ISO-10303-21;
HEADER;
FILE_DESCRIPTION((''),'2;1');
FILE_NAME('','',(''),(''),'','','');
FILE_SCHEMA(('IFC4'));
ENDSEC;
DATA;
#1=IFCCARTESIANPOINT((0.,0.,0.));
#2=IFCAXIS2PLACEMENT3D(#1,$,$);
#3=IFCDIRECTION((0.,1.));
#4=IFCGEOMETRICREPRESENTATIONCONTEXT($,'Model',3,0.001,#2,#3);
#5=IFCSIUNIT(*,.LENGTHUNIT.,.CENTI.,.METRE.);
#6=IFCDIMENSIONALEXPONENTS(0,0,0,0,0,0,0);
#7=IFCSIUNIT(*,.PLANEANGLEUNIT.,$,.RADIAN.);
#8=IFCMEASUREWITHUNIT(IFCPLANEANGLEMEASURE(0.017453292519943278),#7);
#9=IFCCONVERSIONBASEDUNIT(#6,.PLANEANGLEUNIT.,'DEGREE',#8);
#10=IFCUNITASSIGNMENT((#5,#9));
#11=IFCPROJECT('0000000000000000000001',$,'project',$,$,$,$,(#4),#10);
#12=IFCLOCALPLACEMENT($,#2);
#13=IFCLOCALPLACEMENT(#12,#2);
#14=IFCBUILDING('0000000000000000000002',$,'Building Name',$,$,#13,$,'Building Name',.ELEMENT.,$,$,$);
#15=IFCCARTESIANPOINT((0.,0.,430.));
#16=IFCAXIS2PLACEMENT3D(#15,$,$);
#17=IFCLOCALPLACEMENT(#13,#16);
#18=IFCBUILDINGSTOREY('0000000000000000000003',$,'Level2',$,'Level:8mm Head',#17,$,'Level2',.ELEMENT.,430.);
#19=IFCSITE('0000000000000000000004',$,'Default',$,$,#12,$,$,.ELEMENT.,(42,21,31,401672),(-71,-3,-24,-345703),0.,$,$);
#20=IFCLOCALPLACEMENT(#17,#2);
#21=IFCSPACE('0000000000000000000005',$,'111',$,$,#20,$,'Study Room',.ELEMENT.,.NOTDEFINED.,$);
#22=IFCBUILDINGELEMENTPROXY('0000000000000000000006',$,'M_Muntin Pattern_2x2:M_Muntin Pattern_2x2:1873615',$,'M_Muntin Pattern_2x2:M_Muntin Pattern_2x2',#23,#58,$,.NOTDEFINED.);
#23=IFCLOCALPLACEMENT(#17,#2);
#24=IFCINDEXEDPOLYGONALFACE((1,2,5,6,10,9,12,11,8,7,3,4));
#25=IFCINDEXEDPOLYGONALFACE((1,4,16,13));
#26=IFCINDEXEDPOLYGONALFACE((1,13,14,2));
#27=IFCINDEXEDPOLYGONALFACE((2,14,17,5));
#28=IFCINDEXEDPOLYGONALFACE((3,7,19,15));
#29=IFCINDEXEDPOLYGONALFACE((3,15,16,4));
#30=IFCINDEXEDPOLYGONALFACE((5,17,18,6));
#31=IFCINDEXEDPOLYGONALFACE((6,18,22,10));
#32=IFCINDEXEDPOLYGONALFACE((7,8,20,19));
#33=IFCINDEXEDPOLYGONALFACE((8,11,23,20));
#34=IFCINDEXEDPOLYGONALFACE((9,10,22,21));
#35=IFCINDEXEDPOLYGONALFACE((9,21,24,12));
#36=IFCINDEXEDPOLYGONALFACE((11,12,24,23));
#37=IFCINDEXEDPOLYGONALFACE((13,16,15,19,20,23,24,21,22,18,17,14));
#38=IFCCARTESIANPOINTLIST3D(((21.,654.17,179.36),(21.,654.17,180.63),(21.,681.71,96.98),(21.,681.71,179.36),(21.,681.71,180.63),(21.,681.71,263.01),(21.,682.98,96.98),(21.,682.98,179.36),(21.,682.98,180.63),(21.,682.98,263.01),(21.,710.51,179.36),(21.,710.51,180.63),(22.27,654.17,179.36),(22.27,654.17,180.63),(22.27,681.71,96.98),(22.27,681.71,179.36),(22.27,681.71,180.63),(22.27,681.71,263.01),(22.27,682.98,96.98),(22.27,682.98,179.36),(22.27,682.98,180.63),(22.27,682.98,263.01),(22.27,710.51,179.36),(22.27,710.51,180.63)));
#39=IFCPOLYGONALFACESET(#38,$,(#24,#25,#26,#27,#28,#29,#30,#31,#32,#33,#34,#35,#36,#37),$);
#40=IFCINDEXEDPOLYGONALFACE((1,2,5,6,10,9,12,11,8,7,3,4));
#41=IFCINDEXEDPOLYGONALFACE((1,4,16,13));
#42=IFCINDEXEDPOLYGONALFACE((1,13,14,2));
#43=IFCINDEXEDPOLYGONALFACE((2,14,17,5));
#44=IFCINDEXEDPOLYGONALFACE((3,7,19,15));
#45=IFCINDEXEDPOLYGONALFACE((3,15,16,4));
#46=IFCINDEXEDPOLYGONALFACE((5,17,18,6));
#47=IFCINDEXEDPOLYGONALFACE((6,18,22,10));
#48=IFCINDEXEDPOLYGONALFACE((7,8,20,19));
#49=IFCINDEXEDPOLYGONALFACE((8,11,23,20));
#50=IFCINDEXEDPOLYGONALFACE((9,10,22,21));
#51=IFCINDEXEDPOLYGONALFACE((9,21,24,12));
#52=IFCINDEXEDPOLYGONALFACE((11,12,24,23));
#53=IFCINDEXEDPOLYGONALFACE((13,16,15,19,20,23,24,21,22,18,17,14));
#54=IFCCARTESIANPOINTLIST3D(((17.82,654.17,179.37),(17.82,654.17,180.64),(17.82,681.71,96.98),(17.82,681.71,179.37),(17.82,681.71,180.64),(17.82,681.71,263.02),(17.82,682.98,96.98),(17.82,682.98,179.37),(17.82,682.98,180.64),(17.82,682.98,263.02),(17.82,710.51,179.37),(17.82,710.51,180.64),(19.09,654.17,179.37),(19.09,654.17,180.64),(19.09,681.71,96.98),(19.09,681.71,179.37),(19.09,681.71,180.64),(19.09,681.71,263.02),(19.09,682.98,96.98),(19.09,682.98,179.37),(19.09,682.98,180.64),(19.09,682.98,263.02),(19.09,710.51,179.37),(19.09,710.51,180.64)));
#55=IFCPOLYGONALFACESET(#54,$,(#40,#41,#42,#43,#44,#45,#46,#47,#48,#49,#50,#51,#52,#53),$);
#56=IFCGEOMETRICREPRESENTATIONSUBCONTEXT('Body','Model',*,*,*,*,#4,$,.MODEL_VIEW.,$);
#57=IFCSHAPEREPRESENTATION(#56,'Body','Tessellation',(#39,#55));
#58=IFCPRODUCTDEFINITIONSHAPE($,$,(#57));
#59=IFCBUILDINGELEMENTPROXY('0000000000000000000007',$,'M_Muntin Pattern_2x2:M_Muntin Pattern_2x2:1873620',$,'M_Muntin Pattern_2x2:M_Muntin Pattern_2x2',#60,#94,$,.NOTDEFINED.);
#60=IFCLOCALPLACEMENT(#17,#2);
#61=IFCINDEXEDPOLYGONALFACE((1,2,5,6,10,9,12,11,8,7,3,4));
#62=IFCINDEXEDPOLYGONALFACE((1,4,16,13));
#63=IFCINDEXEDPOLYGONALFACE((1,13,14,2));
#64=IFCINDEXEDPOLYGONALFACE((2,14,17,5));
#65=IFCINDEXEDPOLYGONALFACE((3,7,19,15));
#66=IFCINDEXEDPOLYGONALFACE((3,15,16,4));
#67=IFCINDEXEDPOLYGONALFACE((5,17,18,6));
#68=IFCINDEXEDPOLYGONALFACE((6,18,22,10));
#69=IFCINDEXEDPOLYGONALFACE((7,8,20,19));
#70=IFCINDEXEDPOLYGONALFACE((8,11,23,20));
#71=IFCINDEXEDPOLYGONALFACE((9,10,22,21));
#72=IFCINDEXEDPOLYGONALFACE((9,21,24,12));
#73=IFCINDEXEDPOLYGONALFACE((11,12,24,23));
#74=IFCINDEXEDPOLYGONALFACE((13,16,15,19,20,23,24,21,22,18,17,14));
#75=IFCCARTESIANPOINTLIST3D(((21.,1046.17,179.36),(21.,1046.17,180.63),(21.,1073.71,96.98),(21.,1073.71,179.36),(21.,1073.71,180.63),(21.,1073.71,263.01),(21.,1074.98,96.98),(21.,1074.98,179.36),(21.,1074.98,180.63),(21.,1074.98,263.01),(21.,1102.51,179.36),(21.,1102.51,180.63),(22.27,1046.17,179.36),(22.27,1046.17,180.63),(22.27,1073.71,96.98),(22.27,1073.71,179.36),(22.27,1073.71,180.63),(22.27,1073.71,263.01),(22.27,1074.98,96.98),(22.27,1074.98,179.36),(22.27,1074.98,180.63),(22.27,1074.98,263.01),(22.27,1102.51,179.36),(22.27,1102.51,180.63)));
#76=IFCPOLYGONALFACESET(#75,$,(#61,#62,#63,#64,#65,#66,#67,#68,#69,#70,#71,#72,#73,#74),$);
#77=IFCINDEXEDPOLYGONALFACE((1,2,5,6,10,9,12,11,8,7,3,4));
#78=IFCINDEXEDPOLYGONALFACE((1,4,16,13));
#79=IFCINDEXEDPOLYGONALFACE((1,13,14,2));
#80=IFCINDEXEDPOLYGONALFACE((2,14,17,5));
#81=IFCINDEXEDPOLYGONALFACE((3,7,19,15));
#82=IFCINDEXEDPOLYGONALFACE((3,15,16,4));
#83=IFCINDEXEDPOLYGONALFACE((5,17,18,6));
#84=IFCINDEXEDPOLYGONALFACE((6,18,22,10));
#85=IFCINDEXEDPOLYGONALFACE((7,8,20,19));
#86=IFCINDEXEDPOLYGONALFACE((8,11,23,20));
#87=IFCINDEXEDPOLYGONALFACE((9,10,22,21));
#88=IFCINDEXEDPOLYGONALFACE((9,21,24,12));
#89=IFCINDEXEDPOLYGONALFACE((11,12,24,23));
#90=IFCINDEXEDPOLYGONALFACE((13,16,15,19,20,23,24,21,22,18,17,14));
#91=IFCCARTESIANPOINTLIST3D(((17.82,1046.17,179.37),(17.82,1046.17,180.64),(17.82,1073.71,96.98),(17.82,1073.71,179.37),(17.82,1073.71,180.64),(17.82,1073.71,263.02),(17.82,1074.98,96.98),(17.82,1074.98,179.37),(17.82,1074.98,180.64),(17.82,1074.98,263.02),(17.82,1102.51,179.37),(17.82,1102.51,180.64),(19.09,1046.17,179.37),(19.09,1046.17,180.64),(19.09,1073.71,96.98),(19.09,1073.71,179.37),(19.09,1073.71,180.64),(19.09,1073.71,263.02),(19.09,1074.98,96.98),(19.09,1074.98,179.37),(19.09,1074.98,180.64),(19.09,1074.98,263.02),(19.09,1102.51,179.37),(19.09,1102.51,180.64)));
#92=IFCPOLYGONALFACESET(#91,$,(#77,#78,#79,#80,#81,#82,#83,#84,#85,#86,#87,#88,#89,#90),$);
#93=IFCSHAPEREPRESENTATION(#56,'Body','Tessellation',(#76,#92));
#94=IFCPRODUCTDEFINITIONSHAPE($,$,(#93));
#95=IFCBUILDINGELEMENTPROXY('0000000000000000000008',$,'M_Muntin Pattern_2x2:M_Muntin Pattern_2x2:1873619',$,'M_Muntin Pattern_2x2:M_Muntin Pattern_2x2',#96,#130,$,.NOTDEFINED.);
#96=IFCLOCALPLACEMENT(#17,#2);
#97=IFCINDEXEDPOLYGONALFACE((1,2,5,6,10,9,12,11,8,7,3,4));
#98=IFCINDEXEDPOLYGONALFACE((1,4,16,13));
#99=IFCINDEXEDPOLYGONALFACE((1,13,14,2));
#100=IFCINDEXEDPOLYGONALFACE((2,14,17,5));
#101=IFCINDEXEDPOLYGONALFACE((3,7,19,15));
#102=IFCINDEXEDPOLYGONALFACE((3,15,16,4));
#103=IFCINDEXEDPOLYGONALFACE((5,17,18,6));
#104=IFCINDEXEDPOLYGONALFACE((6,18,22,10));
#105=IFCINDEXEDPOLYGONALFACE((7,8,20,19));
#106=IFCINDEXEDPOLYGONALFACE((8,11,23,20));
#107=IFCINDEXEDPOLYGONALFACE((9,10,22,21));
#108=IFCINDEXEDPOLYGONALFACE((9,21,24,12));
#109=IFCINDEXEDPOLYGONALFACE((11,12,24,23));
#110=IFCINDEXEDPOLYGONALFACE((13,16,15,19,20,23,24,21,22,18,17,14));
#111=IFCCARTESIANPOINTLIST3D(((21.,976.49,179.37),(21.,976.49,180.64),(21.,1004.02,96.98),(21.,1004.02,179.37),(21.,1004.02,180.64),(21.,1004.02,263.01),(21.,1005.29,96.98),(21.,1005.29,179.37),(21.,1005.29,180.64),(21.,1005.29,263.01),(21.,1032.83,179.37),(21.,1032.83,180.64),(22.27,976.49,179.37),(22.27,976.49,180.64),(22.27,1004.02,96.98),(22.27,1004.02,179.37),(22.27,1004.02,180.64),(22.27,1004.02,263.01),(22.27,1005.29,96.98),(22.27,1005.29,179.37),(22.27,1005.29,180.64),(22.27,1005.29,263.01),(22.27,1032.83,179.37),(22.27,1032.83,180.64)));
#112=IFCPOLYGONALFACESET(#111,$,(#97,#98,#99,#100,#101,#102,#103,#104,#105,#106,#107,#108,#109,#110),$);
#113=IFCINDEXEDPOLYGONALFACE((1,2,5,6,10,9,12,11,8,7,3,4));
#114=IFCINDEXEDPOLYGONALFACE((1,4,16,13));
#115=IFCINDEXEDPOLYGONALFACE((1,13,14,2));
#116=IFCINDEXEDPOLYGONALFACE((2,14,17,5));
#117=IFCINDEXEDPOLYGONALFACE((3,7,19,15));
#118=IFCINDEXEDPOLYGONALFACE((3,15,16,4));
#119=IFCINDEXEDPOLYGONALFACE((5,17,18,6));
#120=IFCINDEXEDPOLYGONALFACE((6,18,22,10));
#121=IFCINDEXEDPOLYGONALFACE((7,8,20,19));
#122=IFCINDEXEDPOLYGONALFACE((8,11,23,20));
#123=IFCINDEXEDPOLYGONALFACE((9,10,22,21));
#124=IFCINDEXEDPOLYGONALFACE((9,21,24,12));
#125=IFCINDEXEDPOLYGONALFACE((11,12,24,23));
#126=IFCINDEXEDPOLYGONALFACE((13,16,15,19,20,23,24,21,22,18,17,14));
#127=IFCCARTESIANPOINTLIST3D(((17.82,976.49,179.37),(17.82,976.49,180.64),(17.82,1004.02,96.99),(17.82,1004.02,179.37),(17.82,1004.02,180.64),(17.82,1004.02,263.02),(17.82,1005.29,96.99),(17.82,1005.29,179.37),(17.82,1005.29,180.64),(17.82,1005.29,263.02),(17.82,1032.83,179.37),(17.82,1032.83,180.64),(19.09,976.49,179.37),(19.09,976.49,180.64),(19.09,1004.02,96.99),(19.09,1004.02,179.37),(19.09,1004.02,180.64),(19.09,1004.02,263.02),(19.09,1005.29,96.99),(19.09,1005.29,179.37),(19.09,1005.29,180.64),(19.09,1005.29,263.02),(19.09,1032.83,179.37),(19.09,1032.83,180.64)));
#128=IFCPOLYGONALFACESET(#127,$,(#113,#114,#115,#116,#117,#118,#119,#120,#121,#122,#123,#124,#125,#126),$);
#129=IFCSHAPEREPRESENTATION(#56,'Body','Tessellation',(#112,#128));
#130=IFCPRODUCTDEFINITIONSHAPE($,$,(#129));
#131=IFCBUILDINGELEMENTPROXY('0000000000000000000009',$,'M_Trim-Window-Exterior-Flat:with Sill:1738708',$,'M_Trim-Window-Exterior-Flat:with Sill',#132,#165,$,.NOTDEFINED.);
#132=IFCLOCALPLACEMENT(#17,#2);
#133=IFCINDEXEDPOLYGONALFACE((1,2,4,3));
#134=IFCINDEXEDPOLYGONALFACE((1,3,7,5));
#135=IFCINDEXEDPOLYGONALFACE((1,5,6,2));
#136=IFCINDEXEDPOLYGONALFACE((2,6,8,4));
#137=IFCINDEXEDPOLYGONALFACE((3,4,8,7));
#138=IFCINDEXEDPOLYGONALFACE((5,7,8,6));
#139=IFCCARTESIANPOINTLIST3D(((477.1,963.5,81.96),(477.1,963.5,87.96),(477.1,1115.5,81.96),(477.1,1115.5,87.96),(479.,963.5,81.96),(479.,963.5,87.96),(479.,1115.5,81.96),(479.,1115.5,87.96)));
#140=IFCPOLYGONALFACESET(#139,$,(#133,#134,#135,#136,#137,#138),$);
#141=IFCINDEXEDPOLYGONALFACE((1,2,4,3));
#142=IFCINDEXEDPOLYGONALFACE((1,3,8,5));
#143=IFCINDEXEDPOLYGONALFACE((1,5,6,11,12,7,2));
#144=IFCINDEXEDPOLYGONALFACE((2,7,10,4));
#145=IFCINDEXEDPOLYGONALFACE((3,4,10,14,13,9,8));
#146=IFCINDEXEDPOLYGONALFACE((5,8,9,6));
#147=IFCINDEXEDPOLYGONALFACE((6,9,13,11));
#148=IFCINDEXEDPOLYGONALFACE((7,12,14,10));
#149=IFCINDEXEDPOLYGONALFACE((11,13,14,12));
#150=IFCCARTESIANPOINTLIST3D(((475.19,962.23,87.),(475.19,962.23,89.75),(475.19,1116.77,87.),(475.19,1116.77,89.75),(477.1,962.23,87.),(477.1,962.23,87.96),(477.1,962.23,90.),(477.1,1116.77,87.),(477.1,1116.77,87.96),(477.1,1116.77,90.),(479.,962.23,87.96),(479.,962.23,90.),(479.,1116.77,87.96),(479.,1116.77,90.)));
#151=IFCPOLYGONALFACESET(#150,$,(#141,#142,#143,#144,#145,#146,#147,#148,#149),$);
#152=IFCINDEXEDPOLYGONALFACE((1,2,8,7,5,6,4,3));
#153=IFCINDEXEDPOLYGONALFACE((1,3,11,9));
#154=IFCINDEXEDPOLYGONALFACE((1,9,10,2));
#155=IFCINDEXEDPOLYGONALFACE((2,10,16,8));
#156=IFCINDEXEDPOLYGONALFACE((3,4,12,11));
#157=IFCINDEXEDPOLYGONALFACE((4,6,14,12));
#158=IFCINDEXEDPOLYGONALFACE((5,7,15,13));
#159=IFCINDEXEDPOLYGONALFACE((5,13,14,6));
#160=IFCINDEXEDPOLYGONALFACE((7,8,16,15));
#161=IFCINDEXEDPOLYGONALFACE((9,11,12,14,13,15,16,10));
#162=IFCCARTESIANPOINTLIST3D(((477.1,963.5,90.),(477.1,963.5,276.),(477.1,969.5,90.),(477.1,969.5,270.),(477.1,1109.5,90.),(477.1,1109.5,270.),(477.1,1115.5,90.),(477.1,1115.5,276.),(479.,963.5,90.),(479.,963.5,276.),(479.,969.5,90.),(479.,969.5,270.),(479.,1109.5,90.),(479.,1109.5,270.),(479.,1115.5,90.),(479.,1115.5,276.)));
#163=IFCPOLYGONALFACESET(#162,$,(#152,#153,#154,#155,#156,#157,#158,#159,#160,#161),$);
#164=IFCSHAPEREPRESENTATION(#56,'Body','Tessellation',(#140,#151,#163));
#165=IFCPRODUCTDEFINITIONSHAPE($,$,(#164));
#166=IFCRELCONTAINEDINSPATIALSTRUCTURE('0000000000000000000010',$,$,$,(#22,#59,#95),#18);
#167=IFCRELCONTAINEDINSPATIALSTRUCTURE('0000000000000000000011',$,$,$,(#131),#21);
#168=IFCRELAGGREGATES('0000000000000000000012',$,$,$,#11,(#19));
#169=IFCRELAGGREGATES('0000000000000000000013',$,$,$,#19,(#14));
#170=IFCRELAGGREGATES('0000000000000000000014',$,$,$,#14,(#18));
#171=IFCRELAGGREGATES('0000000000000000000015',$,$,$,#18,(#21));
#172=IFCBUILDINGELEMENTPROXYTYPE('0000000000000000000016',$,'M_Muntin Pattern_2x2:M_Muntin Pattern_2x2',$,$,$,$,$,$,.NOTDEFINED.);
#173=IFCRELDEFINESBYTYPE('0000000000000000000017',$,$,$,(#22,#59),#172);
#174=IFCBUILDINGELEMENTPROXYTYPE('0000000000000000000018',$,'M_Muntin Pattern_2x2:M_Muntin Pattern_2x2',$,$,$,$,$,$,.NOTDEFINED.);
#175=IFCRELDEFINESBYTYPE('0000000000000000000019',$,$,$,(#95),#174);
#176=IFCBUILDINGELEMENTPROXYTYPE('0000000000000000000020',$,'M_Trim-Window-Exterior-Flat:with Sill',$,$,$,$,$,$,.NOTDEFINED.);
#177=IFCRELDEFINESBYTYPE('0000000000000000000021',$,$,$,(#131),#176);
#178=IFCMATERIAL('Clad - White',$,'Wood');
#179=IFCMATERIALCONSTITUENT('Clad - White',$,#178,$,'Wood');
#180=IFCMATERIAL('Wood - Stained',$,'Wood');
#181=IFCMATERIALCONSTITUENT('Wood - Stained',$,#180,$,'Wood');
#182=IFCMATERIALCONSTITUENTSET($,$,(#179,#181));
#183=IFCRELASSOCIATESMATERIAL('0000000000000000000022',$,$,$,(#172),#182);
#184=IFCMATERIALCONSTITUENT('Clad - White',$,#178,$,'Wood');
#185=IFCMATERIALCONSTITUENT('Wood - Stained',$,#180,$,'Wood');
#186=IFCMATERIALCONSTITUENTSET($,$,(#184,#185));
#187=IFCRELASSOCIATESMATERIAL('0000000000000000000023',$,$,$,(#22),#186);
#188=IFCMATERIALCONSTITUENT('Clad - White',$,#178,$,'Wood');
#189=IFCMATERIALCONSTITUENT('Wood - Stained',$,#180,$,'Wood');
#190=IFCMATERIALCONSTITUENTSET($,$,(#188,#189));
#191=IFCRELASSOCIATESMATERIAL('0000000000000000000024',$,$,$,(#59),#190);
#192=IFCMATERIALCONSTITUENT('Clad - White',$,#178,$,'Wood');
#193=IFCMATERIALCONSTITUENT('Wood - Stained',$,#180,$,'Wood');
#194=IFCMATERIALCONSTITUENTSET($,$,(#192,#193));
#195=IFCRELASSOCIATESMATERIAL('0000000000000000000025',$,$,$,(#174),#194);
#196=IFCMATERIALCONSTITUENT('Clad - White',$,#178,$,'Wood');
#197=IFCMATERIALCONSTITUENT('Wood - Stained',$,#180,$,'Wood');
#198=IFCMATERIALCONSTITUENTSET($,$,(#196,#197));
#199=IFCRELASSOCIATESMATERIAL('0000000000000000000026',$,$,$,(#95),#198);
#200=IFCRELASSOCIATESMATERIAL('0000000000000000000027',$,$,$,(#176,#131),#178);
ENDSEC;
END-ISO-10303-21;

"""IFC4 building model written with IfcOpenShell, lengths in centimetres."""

from ifc_helpers import new_model, entity, si_unit, converted_unit, direction, frame, origin, place, context, subcontext, project, spatial, indexed_curve, outline, extrude, source, transform, mapped, material, constituent, constituent_set, type_object, type_shapes, element, save


model = new_model("IFC4")

# Units and contexts
model_context = context("Model", 3, precision=0.001, world=origin(), true_north=direction((0.0, 1.0)))
body_context = subcontext(model_context, "Body", "Model", "MODEL_VIEW")
ifc_project = project(units=[si_unit("LENGTHUNIT", "METRE", prefix="CENTI"), converted_unit("PLANEANGLEUNIT", "DEGREE", entity("IfcPlaneAngleMeasure", 0.017453292519943278), si_unit("PLANEANGLEUNIT", "RADIAN"), dimensions=[0, 0, 0, 0, 0, 0, 0])], contexts=[model_context])

# Site, building, storey
site_placement = place(None, origin())
site = spatial("IfcSite", under=ifc_project, at=site_placement, Name="Default", CompositionType="ELEMENT", RefLatitude=(42, 21, 31, 401672), RefLongitude=(-71, -3, -24, -345703), RefElevation=0.0)
building_placement = place(site_placement, origin())
building = spatial("IfcBuilding", under=site, at=building_placement, Name="Building Name", LongName="Building Name", CompositionType="ELEMENT")
storey_placement = place(building_placement, frame((0.0, 0.0, 430.0)))
storey = spatial("IfcBuildingStorey", under=building, at=storey_placement, Name="Level2", ObjectType="Level:8mm Head", LongName="Level2", CompositionType="ELEMENT", Elevation=430.0)

# Shared definitions
space_placement = place(storey_placement, origin())
space = spatial("IfcSpace", under=storey, at=space_placement, Name="111", LongName="Study Room", CompositionType="ELEMENT", PredefinedType="NOTDEFINED")

# Building element proxies
ifc_material_1 = material(Name="Clad - White", Category="Wood")
ifc_constituent_1 = constituent(ifc_material_1, Name="Clad - White", Category="Wood")
ifc_material_2 = material(Name="Wood - Stained", Category="Wood")
ifc_constituent_2 = constituent(ifc_material_2, Name="Wood - Stained", Category="Wood")
ifc_constituent_set_1 = constituent_set(constituents=[ifc_constituent_1, ifc_constituent_2])
ifc_constituent_3 = constituent(ifc_material_1, Name="Clad - White", Category="Wood")
ifc_constituent_4 = constituent(ifc_material_2, Name="Wood - Stained", Category="Wood")
ifc_constituent_set_2 = constituent_set(constituents=[ifc_constituent_3, ifc_constituent_4])
building_element_proxy_type_1 = type_object("IfcBuildingElementProxyType", Name="M_Muntin Pattern_2x2:M_Muntin Pattern_2x2", PredefinedType="NOTDEFINED", material=ifc_constituent_set_2)
shared_shape_1 = source(origin(), body_context, "Body", "SweptSolid", [
    extrude(outline(indexed_curve([(0.64, -0.64), (83.01, -0.64), (83.01, 0.63), (0.64, 0.63), (0.64, 28.17), (-0.63, 28.17), (-0.63, 0.63), (-83.02, 0.63), (-83.02, -0.64), (-0.63, -0.64), (-0.63, -28.17), (0.64, -28.17), (0.64, -0.64)], self_intersect=False)), frame((0.0, 0.95, 83.01), z_axis=(0.0, 1.0, 0.0), x_axis=(0.0, 0.0, 1.0)), (0.0, 0.0, 1.0), 1.27),
    extrude(outline(indexed_curve([(0.64, -0.64), (83.02, -0.64), (83.02, 0.63), (0.64, 0.63), (0.64, 28.17), (-0.63, 28.17), (-0.63, 0.63), (-83.02, 0.63), (-83.02, -0.64), (-0.63, -0.64), (-0.63, -28.17), (0.64, -28.17), (0.64, -0.64)], self_intersect=False)), frame((0.0, -2.22, 83.02), z_axis=(0.0, 1.0, 0.0), x_axis=(0.0, 0.0, 1.0)), (0.0, 0.0, 1.0), 1.27),
])
type_shapes(building_element_proxy_type_1, [shared_shape_1])
proxy_1_placement = place(storey_placement, frame((20.05, 682.34, 96.98), z_axis=(0.0, 0.0, 1.0), x_axis=(0.0, -1.0, 0.0)))
element("IfcBuildingElementProxy", 1, at=proxy_1_placement, inside=storey, type_object=building_element_proxy_type_1, material=ifc_constituent_set_1, Name="M_Muntin Pattern_2x2:M_Muntin Pattern_2x2:1873615", ObjectType="M_Muntin Pattern_2x2:M_Muntin Pattern_2x2", PredefinedType="NOTDEFINED", context=body_context, shape_type="MappedRepresentation", body=[
    mapped(shared_shape_1, transform((0.0, 0.0, 0.0), scale=1.0)),
])
ifc_constituent_5 = constituent(ifc_material_1, Name="Clad - White", Category="Wood")
ifc_constituent_6 = constituent(ifc_material_2, Name="Wood - Stained", Category="Wood")
ifc_constituent_set_3 = constituent_set(constituents=[ifc_constituent_5, ifc_constituent_6])
proxy_2_placement = place(storey_placement, frame((20.05, 1074.34, 96.98), z_axis=(0.0, 0.0, 1.0), x_axis=(0.0, -1.0, 0.0)))
element("IfcBuildingElementProxy", 2, at=proxy_2_placement, inside=storey, type_object=building_element_proxy_type_1, material=ifc_constituent_set_3, Name="M_Muntin Pattern_2x2:M_Muntin Pattern_2x2:1873620", ObjectType="M_Muntin Pattern_2x2:M_Muntin Pattern_2x2", PredefinedType="NOTDEFINED", context=body_context, shape_type="MappedRepresentation", body=[
    mapped(shared_shape_1, transform((0.0, 0.0, 0.0), scale=1.0)),
])
ifc_constituent_7 = constituent(ifc_material_1, Name="Clad - White", Category="Wood")
ifc_constituent_8 = constituent(ifc_material_2, Name="Wood - Stained", Category="Wood")
ifc_constituent_set_4 = constituent_set(constituents=[ifc_constituent_7, ifc_constituent_8])
ifc_constituent_9 = constituent(ifc_material_1, Name="Clad - White", Category="Wood")
ifc_constituent_10 = constituent(ifc_material_2, Name="Wood - Stained", Category="Wood")
ifc_constituent_set_5 = constituent_set(constituents=[ifc_constituent_9, ifc_constituent_10])
building_element_proxy_type_2 = type_object("IfcBuildingElementProxyType", Name="M_Muntin Pattern_2x2:M_Muntin Pattern_2x2", PredefinedType="NOTDEFINED", material=ifc_constituent_set_5)
shared_shape_2 = source(origin(), body_context, "Body", "SweptSolid", [
    extrude(outline(indexed_curve([(0.64, -0.64), (83.01, -0.64), (83.01, 0.63), (0.64, 0.63), (0.64, 28.17), (-0.63, 28.17), (-0.63, 0.63), (-83.02, 0.63), (-83.02, -0.64), (-0.63, -0.64), (-0.63, -28.17), (0.64, -28.17), (0.64, -0.64)], self_intersect=False)), frame((0.0, -2.22, 83.01), z_axis=(0.0, 1.0, 0.0), x_axis=(0.0, 0.0, 1.0)), (0.0, 0.0, 1.0), 1.27),
    extrude(outline(indexed_curve([(0.64, -0.64), (83.02, -0.64), (83.02, 0.63), (0.64, 0.63), (0.64, 28.17), (-0.63, 28.17), (-0.63, 0.63), (-83.02, 0.63), (-83.02, -0.64), (-0.63, -0.64), (-0.63, -28.17), (0.64, -28.17), (0.64, -0.64)], self_intersect=False)), frame((0.0, 0.95, 83.02), z_axis=(0.0, 1.0, 0.0), x_axis=(0.0, 0.0, 1.0)), (0.0, 0.0, 1.0), 1.27),
])
type_shapes(building_element_proxy_type_2, [shared_shape_2])
proxy_3_placement = place(storey_placement, frame((20.05, 1004.66, 96.99), z_axis=(0.0, 0.0, 1.0), x_axis=(0.0, 1.0, 0.0)))
element("IfcBuildingElementProxy", 3, at=proxy_3_placement, inside=storey, type_object=building_element_proxy_type_2, material=ifc_constituent_set_4, Name="M_Muntin Pattern_2x2:M_Muntin Pattern_2x2:1873619", ObjectType="M_Muntin Pattern_2x2:M_Muntin Pattern_2x2", PredefinedType="NOTDEFINED", context=body_context, shape_type="MappedRepresentation", body=[
    mapped(shared_shape_2, transform((0.0, 0.0, 0.0), scale=1.0)),
])
building_element_proxy_type_3 = type_object("IfcBuildingElementProxyType", Name="M_Trim-Window-Exterior-Flat:with Sill", PredefinedType="NOTDEFINED", material=ifc_material_1)
shared_shape_3 = source(origin(), body_context, "Body", "SweptSolid", [
    extrude(outline(indexed_curve([(-3.0, -76.0), (3.0, -76.0), (3.0, 76.0), (-3.0, 76.0), (-3.0, -76.0)], self_intersect=False)), frame((0.0, 185.04, 0.0), z_axis=(0.0, 0.0, 1.0), x_axis=(0.0, 1.0, 0.0)), (0.0, 0.0, 1.0), 1.9),
    extrude(outline(indexed_curve([(-1.52, -1.9), (1.23, -1.9), (1.48, 0.0), (1.48, 1.9), (-0.57, 1.9), (-0.57, 0.0), (-1.52, 0.0), (-1.52, -1.9)], self_intersect=False)), frame((-77.27, 181.48, 1.9), z_axis=(1.0, 0.0, 0.0), x_axis=(0.0, -1.0, 0.0)), (0.0, 0.0, 1.0), 154.54),
    extrude(outline(indexed_curve([(-76.0, -94.5), (76.0, -94.5), (76.0, 91.5), (70.0, 91.5), (70.0, -88.5), (-70.0, -88.5), (-70.0, 91.5), (-76.0, 91.5), (-76.0, -94.5)], self_intersect=False)), frame((0.0, 88.5, 0.0)), (0.0, 0.0, 1.0), 1.9),
])
type_shapes(building_element_proxy_type_3, [shared_shape_3])
proxy_4_placement = place(space_placement, frame((479.0, 1039.5, 270.0), z_axis=(-1.0, 0.0, 0.0), x_axis=(0.0, 1.0, 0.0)))
element("IfcBuildingElementProxy", 4, at=proxy_4_placement, inside=space, type_object=building_element_proxy_type_3, material=ifc_material_1, Name="M_Trim-Window-Exterior-Flat:with Sill:1738708", ObjectType="M_Trim-Window-Exterior-Flat:with Sill", PredefinedType="NOTDEFINED", context=body_context, shape_type="MappedRepresentation", body=[
    mapped(shared_shape_3, transform((0.0, 0.0, 0.0), scale=1.0)),
])

save(model, "model.ifc")
